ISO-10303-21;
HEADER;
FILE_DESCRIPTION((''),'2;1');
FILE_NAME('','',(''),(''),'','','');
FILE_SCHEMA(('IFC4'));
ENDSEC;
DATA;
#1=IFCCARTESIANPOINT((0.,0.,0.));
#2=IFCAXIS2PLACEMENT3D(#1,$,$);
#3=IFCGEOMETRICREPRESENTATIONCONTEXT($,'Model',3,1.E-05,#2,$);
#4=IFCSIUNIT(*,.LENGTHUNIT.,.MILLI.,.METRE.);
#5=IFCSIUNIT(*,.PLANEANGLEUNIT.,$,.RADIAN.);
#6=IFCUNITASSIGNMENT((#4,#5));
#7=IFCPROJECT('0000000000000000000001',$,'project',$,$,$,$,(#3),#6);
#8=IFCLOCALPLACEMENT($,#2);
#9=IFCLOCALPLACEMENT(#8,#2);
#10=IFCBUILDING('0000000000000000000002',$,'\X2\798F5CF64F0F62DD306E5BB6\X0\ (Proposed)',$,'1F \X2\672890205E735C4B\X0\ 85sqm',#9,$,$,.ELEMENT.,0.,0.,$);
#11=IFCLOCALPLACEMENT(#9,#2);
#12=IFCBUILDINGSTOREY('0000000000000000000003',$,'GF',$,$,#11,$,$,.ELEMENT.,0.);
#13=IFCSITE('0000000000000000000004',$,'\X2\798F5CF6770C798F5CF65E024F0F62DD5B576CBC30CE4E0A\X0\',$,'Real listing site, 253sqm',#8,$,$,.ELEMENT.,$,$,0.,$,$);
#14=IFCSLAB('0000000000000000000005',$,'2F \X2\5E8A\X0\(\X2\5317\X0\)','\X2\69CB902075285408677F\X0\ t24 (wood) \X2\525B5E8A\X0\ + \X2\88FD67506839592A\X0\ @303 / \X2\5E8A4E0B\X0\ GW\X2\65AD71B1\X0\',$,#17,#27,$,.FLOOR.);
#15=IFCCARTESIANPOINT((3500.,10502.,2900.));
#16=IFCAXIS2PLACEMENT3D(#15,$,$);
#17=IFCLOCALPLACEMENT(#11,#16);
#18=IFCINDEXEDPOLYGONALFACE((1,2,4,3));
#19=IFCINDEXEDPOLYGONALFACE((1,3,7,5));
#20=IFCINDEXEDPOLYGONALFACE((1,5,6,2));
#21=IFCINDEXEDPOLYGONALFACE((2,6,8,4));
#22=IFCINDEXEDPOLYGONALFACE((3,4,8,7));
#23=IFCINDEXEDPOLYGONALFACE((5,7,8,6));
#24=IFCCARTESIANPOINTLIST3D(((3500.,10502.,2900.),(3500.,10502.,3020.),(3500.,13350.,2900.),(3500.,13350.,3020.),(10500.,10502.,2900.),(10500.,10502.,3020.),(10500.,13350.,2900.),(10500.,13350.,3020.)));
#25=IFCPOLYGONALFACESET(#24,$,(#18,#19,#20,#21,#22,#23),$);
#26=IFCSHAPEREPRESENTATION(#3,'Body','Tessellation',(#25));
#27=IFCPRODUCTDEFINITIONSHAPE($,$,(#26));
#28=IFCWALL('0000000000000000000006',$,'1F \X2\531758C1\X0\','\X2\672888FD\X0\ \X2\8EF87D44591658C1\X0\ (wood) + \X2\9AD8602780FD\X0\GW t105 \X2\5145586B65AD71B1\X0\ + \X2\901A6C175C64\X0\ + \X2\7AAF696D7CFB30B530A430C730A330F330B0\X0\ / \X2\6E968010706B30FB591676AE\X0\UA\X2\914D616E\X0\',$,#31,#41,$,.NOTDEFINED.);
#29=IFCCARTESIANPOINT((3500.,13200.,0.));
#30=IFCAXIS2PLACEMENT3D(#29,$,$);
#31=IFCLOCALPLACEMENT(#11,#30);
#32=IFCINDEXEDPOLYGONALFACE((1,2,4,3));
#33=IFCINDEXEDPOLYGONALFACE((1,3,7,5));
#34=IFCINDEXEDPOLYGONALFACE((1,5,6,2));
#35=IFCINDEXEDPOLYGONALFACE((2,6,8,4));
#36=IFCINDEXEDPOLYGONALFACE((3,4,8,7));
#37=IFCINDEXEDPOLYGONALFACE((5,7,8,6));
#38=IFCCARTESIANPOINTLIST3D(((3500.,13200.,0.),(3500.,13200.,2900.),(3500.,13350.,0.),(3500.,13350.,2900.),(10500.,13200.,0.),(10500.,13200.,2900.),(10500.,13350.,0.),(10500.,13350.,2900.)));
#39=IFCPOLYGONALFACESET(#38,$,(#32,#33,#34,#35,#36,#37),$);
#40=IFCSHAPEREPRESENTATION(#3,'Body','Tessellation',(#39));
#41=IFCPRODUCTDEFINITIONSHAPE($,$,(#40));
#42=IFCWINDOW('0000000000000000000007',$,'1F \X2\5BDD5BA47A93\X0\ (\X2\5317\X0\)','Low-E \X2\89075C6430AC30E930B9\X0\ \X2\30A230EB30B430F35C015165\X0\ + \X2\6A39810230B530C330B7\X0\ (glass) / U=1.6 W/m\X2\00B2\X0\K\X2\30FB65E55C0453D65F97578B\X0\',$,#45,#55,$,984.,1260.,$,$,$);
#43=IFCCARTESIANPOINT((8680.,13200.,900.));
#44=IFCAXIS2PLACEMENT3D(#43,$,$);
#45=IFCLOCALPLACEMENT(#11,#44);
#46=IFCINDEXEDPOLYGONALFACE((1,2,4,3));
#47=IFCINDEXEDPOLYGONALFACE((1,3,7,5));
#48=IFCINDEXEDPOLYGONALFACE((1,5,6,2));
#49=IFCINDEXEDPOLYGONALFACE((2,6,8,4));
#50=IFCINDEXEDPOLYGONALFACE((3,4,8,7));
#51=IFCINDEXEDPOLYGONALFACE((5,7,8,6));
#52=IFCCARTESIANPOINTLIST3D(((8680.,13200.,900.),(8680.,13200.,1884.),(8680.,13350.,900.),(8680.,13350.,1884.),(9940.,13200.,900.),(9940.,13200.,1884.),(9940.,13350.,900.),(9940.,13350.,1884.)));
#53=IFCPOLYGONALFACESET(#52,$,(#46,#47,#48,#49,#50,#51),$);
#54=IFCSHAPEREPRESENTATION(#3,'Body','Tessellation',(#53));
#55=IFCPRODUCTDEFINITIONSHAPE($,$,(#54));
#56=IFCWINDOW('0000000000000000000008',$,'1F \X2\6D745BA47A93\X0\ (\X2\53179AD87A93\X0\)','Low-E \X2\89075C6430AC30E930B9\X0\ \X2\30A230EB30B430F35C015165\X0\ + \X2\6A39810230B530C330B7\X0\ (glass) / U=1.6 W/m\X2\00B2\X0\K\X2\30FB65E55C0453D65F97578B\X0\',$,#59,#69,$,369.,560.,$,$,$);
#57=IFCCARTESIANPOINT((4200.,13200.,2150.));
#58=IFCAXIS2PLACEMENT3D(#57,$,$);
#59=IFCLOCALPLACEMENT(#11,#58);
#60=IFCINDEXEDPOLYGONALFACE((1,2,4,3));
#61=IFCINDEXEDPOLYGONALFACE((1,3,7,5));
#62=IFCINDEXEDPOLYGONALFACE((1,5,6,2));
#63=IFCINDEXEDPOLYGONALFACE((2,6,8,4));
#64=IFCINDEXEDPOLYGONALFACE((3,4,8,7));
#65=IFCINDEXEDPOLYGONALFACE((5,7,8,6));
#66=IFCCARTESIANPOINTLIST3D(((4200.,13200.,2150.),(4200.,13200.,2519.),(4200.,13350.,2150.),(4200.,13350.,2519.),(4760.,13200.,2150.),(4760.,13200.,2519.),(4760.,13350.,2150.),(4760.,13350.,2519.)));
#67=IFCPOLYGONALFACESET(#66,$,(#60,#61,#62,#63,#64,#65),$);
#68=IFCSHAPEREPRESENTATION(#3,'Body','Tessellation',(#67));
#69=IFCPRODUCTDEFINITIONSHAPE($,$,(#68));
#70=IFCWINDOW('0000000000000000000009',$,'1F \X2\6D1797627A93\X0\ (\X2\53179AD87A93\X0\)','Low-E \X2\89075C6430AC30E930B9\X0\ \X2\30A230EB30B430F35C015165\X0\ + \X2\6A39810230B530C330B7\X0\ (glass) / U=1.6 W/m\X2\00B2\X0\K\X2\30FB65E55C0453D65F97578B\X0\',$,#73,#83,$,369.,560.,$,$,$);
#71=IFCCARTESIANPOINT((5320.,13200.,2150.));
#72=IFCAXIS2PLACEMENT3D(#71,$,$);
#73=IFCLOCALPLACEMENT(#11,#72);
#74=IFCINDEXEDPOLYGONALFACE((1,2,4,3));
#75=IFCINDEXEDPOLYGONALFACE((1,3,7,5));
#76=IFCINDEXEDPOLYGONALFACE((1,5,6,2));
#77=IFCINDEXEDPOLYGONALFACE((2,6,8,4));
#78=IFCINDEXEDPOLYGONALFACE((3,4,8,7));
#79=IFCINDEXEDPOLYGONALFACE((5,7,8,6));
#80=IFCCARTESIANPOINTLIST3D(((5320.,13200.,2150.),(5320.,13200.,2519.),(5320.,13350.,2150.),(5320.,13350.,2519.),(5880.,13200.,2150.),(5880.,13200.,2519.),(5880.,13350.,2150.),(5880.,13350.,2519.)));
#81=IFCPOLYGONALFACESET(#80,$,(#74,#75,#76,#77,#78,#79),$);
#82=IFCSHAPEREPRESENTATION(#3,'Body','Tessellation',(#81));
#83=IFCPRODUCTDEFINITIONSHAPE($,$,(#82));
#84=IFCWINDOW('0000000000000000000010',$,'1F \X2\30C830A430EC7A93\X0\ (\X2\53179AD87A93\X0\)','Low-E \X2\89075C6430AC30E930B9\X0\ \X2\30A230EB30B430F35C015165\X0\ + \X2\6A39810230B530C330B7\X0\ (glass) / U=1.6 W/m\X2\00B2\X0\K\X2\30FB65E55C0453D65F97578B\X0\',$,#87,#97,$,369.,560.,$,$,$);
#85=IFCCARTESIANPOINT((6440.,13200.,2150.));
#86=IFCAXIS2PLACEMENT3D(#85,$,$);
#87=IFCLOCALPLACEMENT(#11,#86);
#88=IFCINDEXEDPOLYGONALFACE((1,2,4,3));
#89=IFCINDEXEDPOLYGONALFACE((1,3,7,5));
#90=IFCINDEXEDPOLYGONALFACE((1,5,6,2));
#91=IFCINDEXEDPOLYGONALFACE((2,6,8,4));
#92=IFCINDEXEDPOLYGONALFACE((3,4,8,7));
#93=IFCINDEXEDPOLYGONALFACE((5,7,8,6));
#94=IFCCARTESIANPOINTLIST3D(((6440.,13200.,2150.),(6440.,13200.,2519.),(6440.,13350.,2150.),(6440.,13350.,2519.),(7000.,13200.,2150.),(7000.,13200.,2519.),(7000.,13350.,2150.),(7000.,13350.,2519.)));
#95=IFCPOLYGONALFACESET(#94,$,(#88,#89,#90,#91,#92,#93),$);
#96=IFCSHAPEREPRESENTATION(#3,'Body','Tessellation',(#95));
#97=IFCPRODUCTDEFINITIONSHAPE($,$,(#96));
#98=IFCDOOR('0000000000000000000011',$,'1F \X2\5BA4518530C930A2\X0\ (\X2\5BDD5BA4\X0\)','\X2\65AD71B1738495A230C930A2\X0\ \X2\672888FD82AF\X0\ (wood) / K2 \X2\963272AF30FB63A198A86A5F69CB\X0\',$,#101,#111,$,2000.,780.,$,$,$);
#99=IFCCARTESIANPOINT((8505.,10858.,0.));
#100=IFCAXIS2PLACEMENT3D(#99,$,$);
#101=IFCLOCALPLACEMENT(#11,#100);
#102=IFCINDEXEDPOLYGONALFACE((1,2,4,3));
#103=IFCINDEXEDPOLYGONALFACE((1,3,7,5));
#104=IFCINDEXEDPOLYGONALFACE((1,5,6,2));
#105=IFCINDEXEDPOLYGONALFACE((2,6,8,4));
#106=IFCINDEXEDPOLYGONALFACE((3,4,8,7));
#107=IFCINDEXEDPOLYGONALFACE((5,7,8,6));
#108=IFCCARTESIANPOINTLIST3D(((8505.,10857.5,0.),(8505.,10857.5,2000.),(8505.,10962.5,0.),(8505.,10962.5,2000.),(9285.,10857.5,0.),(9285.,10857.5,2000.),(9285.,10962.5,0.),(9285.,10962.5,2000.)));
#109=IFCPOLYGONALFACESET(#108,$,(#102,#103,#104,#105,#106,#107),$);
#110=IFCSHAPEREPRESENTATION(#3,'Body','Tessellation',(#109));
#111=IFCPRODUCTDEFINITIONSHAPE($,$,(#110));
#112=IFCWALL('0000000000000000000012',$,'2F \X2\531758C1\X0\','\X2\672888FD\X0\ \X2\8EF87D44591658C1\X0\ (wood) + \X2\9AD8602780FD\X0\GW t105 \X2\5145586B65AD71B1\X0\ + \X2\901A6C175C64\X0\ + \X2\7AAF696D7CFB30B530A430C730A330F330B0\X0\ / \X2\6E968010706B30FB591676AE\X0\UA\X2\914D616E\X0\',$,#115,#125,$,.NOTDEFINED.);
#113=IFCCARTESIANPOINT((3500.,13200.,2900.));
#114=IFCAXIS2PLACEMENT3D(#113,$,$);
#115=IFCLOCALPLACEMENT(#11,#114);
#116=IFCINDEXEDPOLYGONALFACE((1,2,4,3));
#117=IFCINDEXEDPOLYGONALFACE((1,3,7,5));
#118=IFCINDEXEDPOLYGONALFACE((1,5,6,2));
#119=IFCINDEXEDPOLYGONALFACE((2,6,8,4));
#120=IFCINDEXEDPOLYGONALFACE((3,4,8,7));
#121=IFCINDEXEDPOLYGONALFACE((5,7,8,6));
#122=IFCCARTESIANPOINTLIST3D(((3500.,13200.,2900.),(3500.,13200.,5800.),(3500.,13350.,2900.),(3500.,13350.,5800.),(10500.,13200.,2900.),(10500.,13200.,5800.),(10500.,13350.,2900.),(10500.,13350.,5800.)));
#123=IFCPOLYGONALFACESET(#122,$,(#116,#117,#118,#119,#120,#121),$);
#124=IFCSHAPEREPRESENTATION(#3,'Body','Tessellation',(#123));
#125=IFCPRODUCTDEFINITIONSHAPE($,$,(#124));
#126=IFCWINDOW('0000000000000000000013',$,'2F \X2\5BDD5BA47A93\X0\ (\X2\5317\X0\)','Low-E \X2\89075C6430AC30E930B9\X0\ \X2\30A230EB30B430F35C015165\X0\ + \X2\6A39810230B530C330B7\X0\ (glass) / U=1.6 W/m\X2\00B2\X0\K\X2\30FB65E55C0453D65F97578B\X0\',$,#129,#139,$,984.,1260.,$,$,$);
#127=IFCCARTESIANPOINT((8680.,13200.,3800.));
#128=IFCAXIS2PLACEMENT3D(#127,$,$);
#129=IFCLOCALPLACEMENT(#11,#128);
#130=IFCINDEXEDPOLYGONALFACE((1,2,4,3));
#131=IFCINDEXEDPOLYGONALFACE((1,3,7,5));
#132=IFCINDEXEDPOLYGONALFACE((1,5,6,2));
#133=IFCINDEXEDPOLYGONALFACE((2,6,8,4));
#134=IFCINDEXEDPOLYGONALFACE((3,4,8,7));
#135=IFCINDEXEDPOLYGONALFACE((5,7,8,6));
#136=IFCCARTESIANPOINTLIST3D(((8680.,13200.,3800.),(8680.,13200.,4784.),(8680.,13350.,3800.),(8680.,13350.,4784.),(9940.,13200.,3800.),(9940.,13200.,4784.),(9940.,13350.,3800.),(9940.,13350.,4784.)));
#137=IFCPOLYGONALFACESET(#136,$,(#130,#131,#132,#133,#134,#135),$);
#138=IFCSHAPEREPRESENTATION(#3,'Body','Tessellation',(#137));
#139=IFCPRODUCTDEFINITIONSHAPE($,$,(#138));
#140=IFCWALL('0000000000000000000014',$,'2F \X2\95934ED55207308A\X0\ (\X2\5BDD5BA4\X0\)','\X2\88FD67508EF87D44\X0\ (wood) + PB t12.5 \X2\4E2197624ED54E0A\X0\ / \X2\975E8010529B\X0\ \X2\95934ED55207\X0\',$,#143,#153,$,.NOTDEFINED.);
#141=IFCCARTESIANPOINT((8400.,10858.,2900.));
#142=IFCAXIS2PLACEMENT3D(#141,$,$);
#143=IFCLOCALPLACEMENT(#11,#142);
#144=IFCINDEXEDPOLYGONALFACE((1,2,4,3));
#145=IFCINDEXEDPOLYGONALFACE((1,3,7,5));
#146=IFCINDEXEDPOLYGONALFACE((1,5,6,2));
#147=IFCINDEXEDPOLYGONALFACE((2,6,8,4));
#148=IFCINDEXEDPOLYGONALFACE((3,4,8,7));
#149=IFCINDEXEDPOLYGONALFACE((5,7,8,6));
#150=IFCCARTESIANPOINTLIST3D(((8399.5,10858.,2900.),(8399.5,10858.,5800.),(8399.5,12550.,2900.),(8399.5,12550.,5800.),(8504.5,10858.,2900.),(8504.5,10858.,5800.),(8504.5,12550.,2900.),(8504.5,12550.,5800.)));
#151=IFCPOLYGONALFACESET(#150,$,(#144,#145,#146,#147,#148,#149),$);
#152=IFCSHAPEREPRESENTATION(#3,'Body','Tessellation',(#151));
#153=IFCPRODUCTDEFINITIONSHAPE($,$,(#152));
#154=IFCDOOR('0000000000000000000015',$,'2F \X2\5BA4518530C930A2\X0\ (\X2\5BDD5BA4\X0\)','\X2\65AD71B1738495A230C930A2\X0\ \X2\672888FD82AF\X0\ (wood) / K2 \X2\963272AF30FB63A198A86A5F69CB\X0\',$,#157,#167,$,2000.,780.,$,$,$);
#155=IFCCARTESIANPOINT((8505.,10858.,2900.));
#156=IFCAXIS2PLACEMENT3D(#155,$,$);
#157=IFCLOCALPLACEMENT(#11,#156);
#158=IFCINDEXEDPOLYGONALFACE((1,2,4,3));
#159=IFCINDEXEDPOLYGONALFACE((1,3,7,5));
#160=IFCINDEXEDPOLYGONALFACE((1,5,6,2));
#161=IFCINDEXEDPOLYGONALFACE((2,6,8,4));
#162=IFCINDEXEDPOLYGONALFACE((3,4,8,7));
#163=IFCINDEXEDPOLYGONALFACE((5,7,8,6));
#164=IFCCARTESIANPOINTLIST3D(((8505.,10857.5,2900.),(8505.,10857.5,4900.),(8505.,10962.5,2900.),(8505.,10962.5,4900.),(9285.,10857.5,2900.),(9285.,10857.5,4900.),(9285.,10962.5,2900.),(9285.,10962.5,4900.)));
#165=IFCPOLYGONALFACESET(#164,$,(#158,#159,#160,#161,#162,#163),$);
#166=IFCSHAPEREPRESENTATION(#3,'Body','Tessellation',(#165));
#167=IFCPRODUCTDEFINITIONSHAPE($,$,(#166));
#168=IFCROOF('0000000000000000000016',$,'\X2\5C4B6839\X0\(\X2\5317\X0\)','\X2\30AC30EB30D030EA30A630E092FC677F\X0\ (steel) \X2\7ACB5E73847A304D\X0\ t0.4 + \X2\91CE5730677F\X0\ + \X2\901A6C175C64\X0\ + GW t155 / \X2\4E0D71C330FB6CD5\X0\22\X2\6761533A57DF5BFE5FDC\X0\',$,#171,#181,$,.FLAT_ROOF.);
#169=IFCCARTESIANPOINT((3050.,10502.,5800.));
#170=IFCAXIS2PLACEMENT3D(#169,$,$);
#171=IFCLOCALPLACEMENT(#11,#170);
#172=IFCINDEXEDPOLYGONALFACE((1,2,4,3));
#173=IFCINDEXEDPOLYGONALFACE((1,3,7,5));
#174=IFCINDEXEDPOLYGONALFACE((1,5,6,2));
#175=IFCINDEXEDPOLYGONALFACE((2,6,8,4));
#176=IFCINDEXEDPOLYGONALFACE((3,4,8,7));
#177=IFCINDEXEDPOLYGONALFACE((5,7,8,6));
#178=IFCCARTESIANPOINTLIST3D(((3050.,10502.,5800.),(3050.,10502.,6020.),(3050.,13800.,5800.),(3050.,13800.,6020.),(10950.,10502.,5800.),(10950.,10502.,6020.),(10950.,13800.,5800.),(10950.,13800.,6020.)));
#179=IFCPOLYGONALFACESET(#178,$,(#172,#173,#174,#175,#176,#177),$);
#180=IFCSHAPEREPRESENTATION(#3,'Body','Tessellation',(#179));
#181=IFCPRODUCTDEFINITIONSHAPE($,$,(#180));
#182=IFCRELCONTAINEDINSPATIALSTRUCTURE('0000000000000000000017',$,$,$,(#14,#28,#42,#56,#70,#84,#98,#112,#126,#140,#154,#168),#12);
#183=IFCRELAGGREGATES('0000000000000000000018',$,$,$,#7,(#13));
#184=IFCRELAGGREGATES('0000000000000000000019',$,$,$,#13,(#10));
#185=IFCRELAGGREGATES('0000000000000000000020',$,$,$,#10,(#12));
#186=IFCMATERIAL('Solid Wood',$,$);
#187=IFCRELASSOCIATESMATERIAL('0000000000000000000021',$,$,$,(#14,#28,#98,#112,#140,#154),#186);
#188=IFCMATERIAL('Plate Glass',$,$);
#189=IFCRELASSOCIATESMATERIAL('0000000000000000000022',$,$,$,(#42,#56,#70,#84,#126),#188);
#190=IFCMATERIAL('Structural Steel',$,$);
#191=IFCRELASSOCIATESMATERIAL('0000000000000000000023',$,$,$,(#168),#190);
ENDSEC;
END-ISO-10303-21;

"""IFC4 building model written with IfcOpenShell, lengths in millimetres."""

from ifc_helpers import new_model, si_unit, frame, frame_2d, origin, place, context, project, spatial, rectangle, extrude, material, element, fill, save


model = new_model("IFC4")

# Units and contexts
model_context = context("Model", 3, precision=1e-05, world=origin())
ifc_project = project(units=[si_unit("LENGTHUNIT", "METRE", prefix="MILLI"), si_unit("PLANEANGLEUNIT", "RADIAN")], contexts=[model_context])

# Site, building, storey
site_placement = place(None, origin())
site = spatial("IfcSite", under=ifc_project, at=site_placement, Name="福島県福島市伏拝字沼ノ上", ObjectType="Real listing site, 253sqm", CompositionType="ELEMENT", RefElevation=0.0)
building_placement = place(site_placement, origin())
building = spatial("IfcBuilding", under=site, at=building_placement, Name="福島伏拝の家 (Proposed)", ObjectType="1F 木造平屋 85sqm", CompositionType="ELEMENT", ElevationOfRefHeight=0.0, ElevationOfTerrain=0.0)
storey_placement = place(building_placement, origin())
storey = spatial("IfcBuildingStorey", under=building, at=storey_placement, Name="GF", CompositionType="ELEMENT", Elevation=0.0)

# Slab
ifc_material_1 = material(Name="Solid Wood")
slab_placement = place(storey_placement, frame((3500.0, 10502.0, 2900.0)))
element("IfcSlab", 1, at=slab_placement, inside=storey, material=ifc_material_1, Name="2F 床(北)", Description="構造用合板 t24 (wood) 剛床 + 製材根太 @303 / 床下 GW断熱", PredefinedType="FLOOR", context=model_context, shape_type="SweptSolid", body=[
    extrude(rectangle(XDim=7000.0, YDim=2848.0, at=frame_2d((3500.0, 1424.0))), frame((3500.0, 10502.0, 2900.0)), (0.0, 0.0, 1.0), 120.0),
])

# Wall, openings, windows
wall_1_placement = place(storey_placement, frame((3500.0, 13200.0, 0.0)))
wall_1 = element("IfcWall", 2, at=wall_1_placement, inside=storey, material=ifc_material_1, Name="1F 北壁", Description="木製 軸組外壁 (wood) + 高性能GW t105 充填断熱 + 通気層 + 窯業系サイディング / 準耐火・外皮UA配慮", PredefinedType="NOTDEFINED", context=model_context, shape_type="SweptSolid", body=[
    extrude(rectangle(XDim=7000.0, YDim=150.0, at=frame_2d((3500.0, 75.0))), frame((3500.0, 13200.0, 0.0)), (0.0, 0.0, 1.0), 2900.0),
])
opening_1_placement = place(storey_placement, frame((8680.0, 13200.0, 900.0)))
opening_1 = element("IfcOpeningElement", 3, at=opening_1_placement, cuts=wall_1, PredefinedType="NOTDEFINED", context=model_context, shape_type="SweptSolid", body=[
    extrude(rectangle(XDim=1260.0, YDim=150.0, at=frame_2d((630.0, 75.0))), frame((8680.0, 13200.0, 900.0)), (0.0, 0.0, 1.0), 984.0),
])
opening_2_placement = place(storey_placement, frame((4200.0, 13200.0, 2150.0)))
opening_2 = element("IfcOpeningElement", 4, at=opening_2_placement, cuts=wall_1, PredefinedType="NOTDEFINED", context=model_context, shape_type="SweptSolid", body=[
    extrude(rectangle(XDim=560.0, YDim=150.0, at=frame_2d((280.0, 75.0))), frame((4200.0, 13200.0, 2150.0)), (0.0, 0.0, 1.0), 369.0),
])
opening_3_placement = place(storey_placement, frame((5320.0, 13200.0, 2150.0)))
opening_3 = element("IfcOpeningElement", 5, at=opening_3_placement, cuts=wall_1, PredefinedType="NOTDEFINED", context=model_context, shape_type="SweptSolid", body=[
    extrude(rectangle(XDim=560.0, YDim=150.0, at=frame_2d((280.0, 75.0))), frame((5320.0, 13200.0, 2150.0)), (0.0, 0.0, 1.0), 369.0),
])
opening_4_placement = place(storey_placement, frame((6440.0, 13200.0, 2150.0)))
opening_4 = element("IfcOpeningElement", 6, at=opening_4_placement, cuts=wall_1, PredefinedType="NOTDEFINED", context=model_context, shape_type="SweptSolid", body=[
    extrude(rectangle(XDim=560.0, YDim=150.0, at=frame_2d((280.0, 75.0))), frame((6440.0, 13200.0, 2150.0)), (0.0, 0.0, 1.0), 369.0),
])
ifc_material_2 = material(Name="Plate Glass")
window_1_placement = place(storey_placement, frame((8680.0, 13200.0, 900.0)))
window_1 = element("IfcWindow", 7, at=window_1_placement, inside=storey, material=ifc_material_2, Name="1F 寝室窓 (北)", Description="Low-E 複層ガラス アルゴン封入 + 樹脂サッシ (glass) / U=1.6 W/m²K・日射取得型", OverallHeight=984.0, OverallWidth=1260.0, context=model_context, shape_type="SweptSolid", body=[
    extrude(rectangle(XDim=1260.0, YDim=150.0, at=frame_2d((630.0, 75.0))), frame((8680.0, 13200.0, 900.0)), (0.0, 0.0, 1.0), 984.0),
])
fill(opening_1, window_1)
window_2_placement = place(storey_placement, frame((4200.0, 13200.0, 2150.0)))
window_2 = element("IfcWindow", 8, at=window_2_placement, inside=storey, material=ifc_material_2, Name="1F 浴室窓 (北高窓)", Description="Low-E 複層ガラス アルゴン封入 + 樹脂サッシ (glass) / U=1.6 W/m²K・日射取得型", OverallHeight=369.0, OverallWidth=560.0, context=model_context, shape_type="SweptSolid", body=[
    extrude(rectangle(XDim=560.0, YDim=150.0, at=frame_2d((280.0, 75.0))), frame((4200.0, 13200.0, 2150.0)), (0.0, 0.0, 1.0), 369.0),
])
fill(opening_2, window_2)
window_3_placement = place(storey_placement, frame((5320.0, 13200.0, 2150.0)))
window_3 = element("IfcWindow", 9, at=window_3_placement, inside=storey, material=ifc_material_2, Name="1F 洗面窓 (北高窓)", Description="Low-E 複層ガラス アルゴン封入 + 樹脂サッシ (glass) / U=1.6 W/m²K・日射取得型", OverallHeight=369.0, OverallWidth=560.0, context=model_context, shape_type="SweptSolid", body=[
    extrude(rectangle(XDim=560.0, YDim=150.0, at=frame_2d((280.0, 75.0))), frame((5320.0, 13200.0, 2150.0)), (0.0, 0.0, 1.0), 369.0),
])
fill(opening_3, window_3)
window_4_placement = place(storey_placement, frame((6440.0, 13200.0, 2150.0)))
window_4 = element("IfcWindow", 10, at=window_4_placement, inside=storey, material=ifc_material_2, Name="1F トイレ窓 (北高窓)", Description="Low-E 複層ガラス アルゴン封入 + 樹脂サッシ (glass) / U=1.6 W/m²K・日射取得型", OverallHeight=369.0, OverallWidth=560.0, context=model_context, shape_type="SweptSolid", body=[
    extrude(rectangle(XDim=560.0, YDim=150.0, at=frame_2d((280.0, 75.0))), frame((6440.0, 13200.0, 2150.0)), (0.0, 0.0, 1.0), 369.0),
])
fill(opening_4, window_4)

# Door
door_1_placement = place(storey_placement, frame((8505.0, 10858.0, 0.0)))
element("IfcDoor", 11, at=door_1_placement, inside=storey, material=ifc_material_1, Name="1F 室内ドア (寝室)", Description="断熱玄関ドア 木製芯 (wood) / K2 防犯・採風機構", OverallHeight=2000.0, OverallWidth=780.0, context=model_context, shape_type="SweptSolid", body=[
    extrude(rectangle(XDim=780.0, YDim=105.0, at=frame_2d((390.0, 52.0))), frame((8505.0, 10858.0, 0.0)), (0.0, 0.0, 1.0), 2000.0),
])

# Wall, opening, window
wall_2_placement = place(storey_placement, frame((3500.0, 13200.0, 2900.0)))
wall_2 = element("IfcWall", 12, at=wall_2_placement, inside=storey, material=ifc_material_1, Name="2F 北壁", Description="木製 軸組外壁 (wood) + 高性能GW t105 充填断熱 + 通気層 + 窯業系サイディング / 準耐火・外皮UA配慮", PredefinedType="NOTDEFINED", context=model_context, shape_type="SweptSolid", body=[
    extrude(rectangle(XDim=7000.0, YDim=150.0, at=frame_2d((3500.0, 75.0))), frame((3500.0, 13200.0, 2900.0)), (0.0, 0.0, 1.0), 2900.0),
])
opening_5_placement = place(storey_placement, frame((8680.0, 13200.0, 3800.0)))
opening_5 = element("IfcOpeningElement", 13, at=opening_5_placement, cuts=wall_2, PredefinedType="NOTDEFINED", context=model_context, shape_type="SweptSolid", body=[
    extrude(rectangle(XDim=1260.0, YDim=150.0, at=frame_2d((630.0, 75.0))), frame((8680.0, 13200.0, 3800.0)), (0.0, 0.0, 1.0), 984.0),
])
window_5_placement = place(storey_placement, frame((8680.0, 13200.0, 3800.0)))
window_5 = element("IfcWindow", 14, at=window_5_placement, inside=storey, material=ifc_material_2, Name="2F 寝室窓 (北)", Description="Low-E 複層ガラス アルゴン封入 + 樹脂サッシ (glass) / U=1.6 W/m²K・日射取得型", OverallHeight=984.0, OverallWidth=1260.0, context=model_context, shape_type="SweptSolid", body=[
    extrude(rectangle(XDim=1260.0, YDim=150.0, at=frame_2d((630.0, 75.0))), frame((8680.0, 13200.0, 3800.0)), (0.0, 0.0, 1.0), 984.0),
])
fill(opening_5, window_5)

# Wall
wall_3_placement = place(storey_placement, frame((8400.0, 10858.0, 2900.0)))
element("IfcWall", 15, at=wall_3_placement, inside=storey, material=ifc_material_1, Name="2F 間仕切り (寝室)", Description="製材軸組 (wood) + PB t12.5 両面仕上 / 非耐力 間仕切", PredefinedType="NOTDEFINED", context=model_context, shape_type="SweptSolid", body=[
    extrude(rectangle(XDim=105.0, YDim=1692.0, at=frame_2d((52.0, 846.0))), frame((8400.0, 10858.0, 2900.0)), (0.0, 0.0, 1.0), 2900.0),
])

# Door
door_2_placement = place(storey_placement, frame((8505.0, 10858.0, 2900.0)))
element("IfcDoor", 16, at=door_2_placement, inside=storey, material=ifc_material_1, Name="2F 室内ドア (寝室)", Description="断熱玄関ドア 木製芯 (wood) / K2 防犯・採風機構", OverallHeight=2000.0, OverallWidth=780.0, context=model_context, shape_type="SweptSolid", body=[
    extrude(rectangle(XDim=780.0, YDim=105.0, at=frame_2d((390.0, 52.0))), frame((8505.0, 10858.0, 2900.0)), (0.0, 0.0, 1.0), 2000.0),
])

# Roof
ifc_material_3 = material(Name="Structural Steel")
roof_placement = place(storey_placement, frame((3050.0, 10502.0, 5800.0)))
element("IfcRoof", 17, at=roof_placement, inside=storey, material=ifc_material_3, Name="屋根(北)", Description="ガルバリウム鋼板 (steel) 立平葺き t0.4 + 野地板 + 通気層 + GW t155 / 不燃・法22条区域対応", PredefinedType="FLAT_ROOF", context=model_context, shape_type="SweptSolid", body=[
    extrude(rectangle(XDim=7900.0, YDim=3298.0, at=frame_2d((3950.0, 1649.0))), frame((3050.0, 10502.0, 5800.0)), (0.0, 0.0, 1.0), 220.0),
])

save(model, "model.ifc")
